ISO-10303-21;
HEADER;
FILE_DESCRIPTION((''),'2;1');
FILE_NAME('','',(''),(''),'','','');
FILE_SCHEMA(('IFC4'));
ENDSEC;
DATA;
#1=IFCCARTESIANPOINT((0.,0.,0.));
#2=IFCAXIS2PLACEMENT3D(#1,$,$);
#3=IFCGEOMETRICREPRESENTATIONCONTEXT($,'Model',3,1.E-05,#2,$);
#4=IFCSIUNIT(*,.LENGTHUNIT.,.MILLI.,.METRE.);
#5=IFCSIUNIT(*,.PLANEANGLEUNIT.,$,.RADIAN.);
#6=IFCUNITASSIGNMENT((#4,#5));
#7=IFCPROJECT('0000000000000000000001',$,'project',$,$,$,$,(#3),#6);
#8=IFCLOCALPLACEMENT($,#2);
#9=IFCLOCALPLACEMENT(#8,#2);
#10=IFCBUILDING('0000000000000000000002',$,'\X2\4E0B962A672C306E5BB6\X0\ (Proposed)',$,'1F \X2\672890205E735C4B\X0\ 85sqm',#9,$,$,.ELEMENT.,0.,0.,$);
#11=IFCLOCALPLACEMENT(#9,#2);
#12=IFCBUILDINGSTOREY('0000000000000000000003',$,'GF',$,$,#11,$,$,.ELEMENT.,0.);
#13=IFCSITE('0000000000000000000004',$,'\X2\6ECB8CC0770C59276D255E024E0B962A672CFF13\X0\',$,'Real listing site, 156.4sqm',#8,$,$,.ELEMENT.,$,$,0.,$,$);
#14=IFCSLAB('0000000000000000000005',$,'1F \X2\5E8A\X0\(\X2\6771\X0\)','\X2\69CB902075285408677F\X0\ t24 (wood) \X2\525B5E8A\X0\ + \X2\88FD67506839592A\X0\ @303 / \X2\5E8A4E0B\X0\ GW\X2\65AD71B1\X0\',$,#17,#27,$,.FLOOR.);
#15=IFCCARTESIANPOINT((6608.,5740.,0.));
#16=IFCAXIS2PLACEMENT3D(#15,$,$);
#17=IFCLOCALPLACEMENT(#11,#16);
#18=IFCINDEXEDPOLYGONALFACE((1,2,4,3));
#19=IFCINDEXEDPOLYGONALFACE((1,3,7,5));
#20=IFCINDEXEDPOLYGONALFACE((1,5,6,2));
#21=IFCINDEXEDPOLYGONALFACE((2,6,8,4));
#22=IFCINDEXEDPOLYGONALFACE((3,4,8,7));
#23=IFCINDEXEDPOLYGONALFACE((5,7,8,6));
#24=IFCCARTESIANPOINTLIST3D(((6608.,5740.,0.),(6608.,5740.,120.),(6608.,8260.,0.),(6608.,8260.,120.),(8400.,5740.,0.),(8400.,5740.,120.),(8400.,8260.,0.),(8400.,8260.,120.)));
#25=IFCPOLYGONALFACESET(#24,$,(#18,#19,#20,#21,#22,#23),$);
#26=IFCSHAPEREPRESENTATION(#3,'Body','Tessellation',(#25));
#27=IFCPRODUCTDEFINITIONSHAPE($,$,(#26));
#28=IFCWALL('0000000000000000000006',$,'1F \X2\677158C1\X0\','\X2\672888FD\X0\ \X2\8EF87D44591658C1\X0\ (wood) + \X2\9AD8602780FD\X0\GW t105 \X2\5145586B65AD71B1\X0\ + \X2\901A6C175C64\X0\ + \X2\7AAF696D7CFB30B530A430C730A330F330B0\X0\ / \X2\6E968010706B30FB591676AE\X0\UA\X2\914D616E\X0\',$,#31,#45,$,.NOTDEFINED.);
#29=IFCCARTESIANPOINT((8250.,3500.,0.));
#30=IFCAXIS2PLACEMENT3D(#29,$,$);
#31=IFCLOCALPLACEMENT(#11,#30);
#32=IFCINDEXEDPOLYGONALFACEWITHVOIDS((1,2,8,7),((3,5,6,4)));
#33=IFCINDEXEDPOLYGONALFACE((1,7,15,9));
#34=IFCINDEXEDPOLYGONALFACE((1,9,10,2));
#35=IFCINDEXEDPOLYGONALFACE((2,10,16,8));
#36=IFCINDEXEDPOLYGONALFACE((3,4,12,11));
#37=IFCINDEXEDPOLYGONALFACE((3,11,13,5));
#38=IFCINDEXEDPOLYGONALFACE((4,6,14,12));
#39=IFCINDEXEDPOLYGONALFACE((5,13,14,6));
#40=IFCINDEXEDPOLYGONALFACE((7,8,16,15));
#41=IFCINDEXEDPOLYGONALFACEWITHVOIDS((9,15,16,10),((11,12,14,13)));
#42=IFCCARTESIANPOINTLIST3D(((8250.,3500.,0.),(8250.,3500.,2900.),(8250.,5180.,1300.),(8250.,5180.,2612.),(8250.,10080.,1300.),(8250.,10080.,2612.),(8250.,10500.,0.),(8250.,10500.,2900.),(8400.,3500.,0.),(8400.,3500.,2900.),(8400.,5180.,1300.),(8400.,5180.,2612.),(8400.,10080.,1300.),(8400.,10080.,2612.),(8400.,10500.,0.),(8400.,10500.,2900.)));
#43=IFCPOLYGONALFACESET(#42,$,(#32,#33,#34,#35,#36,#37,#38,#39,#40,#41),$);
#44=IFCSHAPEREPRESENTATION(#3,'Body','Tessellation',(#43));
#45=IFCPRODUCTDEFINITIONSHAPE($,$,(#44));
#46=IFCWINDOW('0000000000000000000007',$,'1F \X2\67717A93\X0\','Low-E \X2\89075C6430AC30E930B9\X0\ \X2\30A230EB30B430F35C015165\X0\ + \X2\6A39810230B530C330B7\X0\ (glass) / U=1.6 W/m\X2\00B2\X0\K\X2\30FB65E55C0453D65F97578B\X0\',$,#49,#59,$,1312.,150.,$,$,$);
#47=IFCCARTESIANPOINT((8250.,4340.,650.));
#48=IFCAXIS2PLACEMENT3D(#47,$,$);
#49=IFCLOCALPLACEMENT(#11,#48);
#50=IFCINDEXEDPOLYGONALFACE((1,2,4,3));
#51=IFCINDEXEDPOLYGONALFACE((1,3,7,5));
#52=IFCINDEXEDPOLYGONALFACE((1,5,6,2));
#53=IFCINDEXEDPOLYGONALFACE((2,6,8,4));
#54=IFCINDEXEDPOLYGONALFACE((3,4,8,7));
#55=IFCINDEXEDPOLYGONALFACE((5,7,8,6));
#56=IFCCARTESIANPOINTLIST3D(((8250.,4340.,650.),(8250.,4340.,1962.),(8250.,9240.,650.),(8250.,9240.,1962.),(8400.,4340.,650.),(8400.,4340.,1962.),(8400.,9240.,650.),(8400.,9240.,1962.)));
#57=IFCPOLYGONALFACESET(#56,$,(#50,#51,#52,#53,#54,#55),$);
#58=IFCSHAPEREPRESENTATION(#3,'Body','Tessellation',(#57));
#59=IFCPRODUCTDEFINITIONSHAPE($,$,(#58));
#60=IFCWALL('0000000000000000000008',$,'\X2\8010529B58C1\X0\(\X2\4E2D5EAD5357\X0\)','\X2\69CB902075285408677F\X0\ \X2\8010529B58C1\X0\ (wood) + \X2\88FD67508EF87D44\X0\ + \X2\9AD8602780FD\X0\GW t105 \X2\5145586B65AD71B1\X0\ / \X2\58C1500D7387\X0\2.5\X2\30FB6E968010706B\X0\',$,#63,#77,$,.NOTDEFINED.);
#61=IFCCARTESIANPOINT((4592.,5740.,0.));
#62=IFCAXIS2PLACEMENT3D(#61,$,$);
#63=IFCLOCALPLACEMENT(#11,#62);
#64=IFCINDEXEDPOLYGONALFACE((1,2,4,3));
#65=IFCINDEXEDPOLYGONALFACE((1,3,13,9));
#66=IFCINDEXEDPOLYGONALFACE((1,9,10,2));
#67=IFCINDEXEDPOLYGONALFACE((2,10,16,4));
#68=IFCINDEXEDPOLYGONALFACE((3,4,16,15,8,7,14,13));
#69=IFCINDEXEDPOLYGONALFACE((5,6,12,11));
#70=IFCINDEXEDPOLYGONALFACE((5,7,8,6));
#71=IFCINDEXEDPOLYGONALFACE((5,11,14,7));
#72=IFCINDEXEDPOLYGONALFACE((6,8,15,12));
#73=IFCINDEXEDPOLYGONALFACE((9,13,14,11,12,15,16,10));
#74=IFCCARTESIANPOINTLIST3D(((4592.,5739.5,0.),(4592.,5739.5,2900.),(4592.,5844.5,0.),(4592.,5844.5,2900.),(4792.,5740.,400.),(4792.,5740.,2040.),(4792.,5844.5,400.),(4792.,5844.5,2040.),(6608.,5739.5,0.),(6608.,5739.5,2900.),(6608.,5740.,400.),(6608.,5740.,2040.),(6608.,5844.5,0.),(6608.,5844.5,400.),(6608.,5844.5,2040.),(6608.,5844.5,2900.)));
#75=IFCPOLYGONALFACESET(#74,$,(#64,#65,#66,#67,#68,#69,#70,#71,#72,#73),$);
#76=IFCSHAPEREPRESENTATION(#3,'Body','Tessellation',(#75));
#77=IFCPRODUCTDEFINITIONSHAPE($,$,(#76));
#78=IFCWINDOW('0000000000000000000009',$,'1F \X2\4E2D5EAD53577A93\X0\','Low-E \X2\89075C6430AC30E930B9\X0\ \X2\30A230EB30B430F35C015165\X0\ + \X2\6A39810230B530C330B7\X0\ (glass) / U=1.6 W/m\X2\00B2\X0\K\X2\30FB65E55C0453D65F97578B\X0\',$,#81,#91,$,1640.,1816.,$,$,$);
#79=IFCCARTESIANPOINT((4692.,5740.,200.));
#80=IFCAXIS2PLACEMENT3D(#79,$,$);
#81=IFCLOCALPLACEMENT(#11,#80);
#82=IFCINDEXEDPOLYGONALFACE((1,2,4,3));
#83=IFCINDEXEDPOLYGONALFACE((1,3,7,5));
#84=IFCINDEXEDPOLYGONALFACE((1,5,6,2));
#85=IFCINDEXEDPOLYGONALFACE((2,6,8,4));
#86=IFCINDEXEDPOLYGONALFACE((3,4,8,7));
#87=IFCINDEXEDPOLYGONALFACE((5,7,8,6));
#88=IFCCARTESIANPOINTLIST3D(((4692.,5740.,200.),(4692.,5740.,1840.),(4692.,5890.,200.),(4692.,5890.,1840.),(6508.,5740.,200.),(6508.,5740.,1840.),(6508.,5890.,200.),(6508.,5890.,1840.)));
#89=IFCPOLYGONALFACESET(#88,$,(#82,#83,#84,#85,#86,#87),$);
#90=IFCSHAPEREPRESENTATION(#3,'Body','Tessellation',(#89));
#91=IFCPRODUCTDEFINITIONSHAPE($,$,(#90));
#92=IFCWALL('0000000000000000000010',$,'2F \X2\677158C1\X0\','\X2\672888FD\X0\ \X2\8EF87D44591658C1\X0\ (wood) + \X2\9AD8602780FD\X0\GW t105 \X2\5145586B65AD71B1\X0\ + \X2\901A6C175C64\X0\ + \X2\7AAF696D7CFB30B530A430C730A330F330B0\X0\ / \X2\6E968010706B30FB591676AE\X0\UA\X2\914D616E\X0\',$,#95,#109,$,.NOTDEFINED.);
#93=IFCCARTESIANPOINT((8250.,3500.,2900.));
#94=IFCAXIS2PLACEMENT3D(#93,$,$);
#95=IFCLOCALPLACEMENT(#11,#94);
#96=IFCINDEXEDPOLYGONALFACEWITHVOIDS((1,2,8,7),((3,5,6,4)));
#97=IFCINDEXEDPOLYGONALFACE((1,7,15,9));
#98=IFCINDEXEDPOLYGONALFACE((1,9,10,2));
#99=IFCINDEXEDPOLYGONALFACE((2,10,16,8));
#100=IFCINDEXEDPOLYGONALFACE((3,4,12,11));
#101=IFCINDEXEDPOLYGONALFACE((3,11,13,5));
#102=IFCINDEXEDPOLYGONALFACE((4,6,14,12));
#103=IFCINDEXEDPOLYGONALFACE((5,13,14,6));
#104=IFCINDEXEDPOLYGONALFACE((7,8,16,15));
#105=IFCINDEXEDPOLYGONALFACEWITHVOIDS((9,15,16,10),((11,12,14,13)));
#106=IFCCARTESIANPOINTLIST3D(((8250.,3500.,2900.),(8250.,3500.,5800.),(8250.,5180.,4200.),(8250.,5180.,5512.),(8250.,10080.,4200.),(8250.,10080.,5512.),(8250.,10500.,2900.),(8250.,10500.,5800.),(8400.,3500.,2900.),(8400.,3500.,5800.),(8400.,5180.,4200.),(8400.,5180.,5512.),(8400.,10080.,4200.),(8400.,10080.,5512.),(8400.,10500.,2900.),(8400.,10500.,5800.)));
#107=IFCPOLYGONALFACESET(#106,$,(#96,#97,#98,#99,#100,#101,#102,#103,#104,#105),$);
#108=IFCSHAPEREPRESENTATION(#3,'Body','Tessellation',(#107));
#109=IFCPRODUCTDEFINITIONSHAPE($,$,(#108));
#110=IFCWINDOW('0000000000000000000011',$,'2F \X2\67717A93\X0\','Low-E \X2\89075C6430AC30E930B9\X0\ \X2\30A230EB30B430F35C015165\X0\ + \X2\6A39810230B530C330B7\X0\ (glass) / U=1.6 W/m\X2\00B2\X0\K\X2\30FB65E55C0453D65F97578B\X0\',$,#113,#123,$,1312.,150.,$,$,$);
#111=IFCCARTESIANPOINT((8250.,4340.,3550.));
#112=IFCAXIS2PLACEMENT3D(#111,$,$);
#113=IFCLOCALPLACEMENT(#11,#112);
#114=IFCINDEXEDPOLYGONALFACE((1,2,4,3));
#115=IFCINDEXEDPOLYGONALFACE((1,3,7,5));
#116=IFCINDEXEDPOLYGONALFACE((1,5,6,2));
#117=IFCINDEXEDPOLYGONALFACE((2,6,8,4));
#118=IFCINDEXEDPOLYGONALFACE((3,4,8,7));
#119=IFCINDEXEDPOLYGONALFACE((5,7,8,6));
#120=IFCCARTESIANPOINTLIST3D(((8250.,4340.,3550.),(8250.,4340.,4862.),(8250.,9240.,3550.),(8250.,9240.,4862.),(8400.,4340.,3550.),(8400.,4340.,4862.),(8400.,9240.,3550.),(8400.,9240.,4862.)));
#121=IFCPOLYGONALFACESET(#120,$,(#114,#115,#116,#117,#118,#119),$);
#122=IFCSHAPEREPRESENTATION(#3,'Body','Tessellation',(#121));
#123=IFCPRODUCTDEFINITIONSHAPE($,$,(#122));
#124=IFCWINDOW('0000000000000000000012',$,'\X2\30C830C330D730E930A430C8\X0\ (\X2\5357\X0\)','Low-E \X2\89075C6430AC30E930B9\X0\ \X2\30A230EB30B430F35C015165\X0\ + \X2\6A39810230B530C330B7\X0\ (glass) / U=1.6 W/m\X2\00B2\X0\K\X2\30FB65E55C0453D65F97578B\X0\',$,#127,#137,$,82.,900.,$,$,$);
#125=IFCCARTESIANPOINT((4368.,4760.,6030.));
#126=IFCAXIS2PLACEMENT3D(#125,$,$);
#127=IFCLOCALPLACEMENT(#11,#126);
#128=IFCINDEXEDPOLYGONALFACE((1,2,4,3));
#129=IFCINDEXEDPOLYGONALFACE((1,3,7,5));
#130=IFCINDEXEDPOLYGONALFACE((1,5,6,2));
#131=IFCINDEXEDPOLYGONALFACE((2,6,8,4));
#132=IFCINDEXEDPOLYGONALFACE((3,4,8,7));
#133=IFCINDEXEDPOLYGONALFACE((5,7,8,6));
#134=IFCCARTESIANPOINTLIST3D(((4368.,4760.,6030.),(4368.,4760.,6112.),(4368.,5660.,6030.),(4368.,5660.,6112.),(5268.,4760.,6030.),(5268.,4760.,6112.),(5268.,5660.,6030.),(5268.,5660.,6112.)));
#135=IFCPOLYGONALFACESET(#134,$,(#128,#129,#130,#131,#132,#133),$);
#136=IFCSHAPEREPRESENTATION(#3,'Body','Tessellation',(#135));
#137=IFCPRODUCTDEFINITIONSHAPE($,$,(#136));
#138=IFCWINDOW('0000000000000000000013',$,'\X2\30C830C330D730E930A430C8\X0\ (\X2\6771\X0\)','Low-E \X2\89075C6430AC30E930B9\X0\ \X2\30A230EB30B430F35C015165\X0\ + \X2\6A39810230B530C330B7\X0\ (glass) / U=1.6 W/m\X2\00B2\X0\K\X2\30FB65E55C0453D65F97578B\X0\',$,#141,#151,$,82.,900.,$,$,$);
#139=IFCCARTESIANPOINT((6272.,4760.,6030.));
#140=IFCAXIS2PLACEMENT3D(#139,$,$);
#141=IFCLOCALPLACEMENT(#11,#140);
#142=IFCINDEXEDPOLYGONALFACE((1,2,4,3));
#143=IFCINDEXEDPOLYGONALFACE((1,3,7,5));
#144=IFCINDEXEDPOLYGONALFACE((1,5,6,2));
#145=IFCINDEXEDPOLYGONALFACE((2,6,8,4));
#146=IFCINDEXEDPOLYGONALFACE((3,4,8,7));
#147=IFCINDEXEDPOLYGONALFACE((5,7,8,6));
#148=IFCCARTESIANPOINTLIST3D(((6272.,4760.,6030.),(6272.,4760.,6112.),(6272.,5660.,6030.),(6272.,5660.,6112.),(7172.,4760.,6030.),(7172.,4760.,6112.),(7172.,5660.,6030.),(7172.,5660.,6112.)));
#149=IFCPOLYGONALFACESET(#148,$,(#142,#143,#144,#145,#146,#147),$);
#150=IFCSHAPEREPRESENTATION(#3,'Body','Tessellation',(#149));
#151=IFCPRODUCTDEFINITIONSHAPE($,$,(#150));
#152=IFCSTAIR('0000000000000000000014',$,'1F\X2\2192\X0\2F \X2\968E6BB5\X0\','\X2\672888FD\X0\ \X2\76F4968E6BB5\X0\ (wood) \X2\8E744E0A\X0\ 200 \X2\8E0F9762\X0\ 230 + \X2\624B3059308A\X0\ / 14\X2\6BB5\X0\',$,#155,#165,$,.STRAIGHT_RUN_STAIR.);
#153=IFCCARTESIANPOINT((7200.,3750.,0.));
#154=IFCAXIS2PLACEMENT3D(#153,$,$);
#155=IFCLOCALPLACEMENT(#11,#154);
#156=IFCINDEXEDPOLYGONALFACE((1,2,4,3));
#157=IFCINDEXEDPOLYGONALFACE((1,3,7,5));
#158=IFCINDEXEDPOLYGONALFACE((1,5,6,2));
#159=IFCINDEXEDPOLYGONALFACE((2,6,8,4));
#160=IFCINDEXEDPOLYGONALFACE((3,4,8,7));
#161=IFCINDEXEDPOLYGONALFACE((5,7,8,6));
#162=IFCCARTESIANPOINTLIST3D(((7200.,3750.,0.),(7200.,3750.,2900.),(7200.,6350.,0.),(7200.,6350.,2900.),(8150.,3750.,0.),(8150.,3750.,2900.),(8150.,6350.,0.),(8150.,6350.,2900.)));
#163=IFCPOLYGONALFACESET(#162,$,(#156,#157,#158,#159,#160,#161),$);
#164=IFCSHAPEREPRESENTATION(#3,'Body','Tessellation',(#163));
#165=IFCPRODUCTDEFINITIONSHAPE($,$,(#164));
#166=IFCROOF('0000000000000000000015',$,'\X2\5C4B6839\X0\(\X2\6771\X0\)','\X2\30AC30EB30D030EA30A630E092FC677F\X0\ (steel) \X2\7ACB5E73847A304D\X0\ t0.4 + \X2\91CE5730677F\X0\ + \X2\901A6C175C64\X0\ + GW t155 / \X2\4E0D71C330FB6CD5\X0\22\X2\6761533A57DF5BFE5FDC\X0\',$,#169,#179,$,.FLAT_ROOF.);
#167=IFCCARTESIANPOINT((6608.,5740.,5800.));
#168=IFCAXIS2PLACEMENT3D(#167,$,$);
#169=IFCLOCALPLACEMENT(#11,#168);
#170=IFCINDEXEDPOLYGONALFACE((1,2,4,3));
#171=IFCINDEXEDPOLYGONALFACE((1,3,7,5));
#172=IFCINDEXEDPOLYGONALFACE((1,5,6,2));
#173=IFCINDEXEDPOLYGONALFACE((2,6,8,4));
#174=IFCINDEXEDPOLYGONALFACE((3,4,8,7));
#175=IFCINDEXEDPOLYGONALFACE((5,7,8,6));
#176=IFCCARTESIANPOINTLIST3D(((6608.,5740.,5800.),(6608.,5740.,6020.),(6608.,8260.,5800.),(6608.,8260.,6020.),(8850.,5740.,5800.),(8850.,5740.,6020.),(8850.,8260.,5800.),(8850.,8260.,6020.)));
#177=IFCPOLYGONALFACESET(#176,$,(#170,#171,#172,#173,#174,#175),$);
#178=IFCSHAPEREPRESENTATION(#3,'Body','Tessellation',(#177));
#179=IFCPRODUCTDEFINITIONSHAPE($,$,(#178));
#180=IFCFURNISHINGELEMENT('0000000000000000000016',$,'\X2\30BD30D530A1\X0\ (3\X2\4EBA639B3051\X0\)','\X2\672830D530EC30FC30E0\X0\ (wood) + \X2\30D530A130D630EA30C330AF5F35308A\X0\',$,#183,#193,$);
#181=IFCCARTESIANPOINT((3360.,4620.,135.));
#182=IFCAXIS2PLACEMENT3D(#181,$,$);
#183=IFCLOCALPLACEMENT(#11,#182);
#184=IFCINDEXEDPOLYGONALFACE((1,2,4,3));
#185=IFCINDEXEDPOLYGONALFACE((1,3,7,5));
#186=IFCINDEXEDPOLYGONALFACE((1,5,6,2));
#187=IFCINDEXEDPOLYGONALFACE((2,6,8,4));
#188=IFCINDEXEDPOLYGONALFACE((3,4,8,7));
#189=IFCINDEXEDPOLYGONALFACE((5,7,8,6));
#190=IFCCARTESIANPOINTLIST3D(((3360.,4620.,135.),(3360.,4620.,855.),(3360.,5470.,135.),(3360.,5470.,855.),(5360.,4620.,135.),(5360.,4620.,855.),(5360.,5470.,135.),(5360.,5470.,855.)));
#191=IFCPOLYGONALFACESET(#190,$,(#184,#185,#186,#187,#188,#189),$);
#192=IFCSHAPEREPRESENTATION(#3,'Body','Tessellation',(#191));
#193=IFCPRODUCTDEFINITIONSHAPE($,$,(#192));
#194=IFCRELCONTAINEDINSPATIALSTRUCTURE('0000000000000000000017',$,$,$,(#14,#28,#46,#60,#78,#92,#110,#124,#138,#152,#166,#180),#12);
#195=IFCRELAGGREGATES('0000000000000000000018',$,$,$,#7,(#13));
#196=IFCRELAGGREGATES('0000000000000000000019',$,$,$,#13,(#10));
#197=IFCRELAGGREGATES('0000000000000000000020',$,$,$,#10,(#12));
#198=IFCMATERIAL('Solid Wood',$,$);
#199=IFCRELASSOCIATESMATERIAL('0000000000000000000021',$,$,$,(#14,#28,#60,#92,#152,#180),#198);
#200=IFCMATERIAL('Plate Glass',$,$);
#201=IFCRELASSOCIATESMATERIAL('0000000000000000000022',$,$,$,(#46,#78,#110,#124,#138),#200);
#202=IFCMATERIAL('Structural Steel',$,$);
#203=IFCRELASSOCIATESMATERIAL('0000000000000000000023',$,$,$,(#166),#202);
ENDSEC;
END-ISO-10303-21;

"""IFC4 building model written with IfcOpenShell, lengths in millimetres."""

from ifc_helpers import new_model, si_unit, frame, frame_2d, origin, place, context, project, spatial, rectangle, extrude, material, element, fill, save


model = new_model("IFC4")

# Units and contexts
model_context = context("Model", 3, precision=1e-05, world=origin())
ifc_project = project(units=[si_unit("LENGTHUNIT", "METRE", prefix="MILLI"), si_unit("PLANEANGLEUNIT", "RADIAN")], contexts=[model_context])

# Site, building, storey
site_placement = place(None, origin())
site = spatial("IfcSite", under=ifc_project, at=site_placement, Name="滋賀県大津市下阪本３", ObjectType="Real listing site, 156.4sqm", CompositionType="ELEMENT", RefElevation=0.0)
building_placement = place(site_placement, origin())
building = spatial("IfcBuilding", under=site, at=building_placement, Name="下阪本の家 (Proposed)", ObjectType="1F 木造平屋 85sqm", CompositionType="ELEMENT", ElevationOfRefHeight=0.0, ElevationOfTerrain=0.0)
storey_placement = place(building_placement, origin())
storey = spatial("IfcBuildingStorey", under=building, at=storey_placement, Name="GF", CompositionType="ELEMENT", Elevation=0.0)

# Slab
ifc_material_1 = material(Name="Solid Wood")
slab_placement = place(storey_placement, frame((6608.0, 5740.0, 0.0)))
element("IfcSlab", 1, at=slab_placement, inside=storey, material=ifc_material_1, Name="1F 床(東)", Description="構造用合板 t24 (wood) 剛床 + 製材根太 @303 / 床下 GW断熱", PredefinedType="FLOOR", context=model_context, shape_type="SweptSolid", body=[
    extrude(rectangle(XDim=1792.0, YDim=2520.0, at=frame_2d((896.0, 1260.0))), frame((6608.0, 5740.0, 0.0)), (0.0, 0.0, 1.0), 120.0),
])

# Walls, openings, windows
wall_1_placement = place(storey_placement, frame((8250.0, 3500.0, 0.0)))
wall_1 = element("IfcWall", 2, at=wall_1_placement, inside=storey, material=ifc_material_1, Name="1F 東壁", Description="木製 軸組外壁 (wood) + 高性能GW t105 充填断熱 + 通気層 + 窯業系サイディング / 準耐火・外皮UA配慮", PredefinedType="NOTDEFINED", context=model_context, shape_type="SweptSolid", body=[
    extrude(rectangle(XDim=150.0, YDim=7000.0, at=frame_2d((75.0, 3500.0))), frame((8250.0, 3500.0, 0.0)), (0.0, 0.0, 1.0), 2900.0),
])
opening_1_placement = place(storey_placement, frame((8250.0, 4340.0, 650.0)))
opening_1 = element("IfcOpeningElement", 3, at=opening_1_placement, cuts=wall_1, PredefinedType="NOTDEFINED", context=model_context, shape_type="SweptSolid", body=[
    extrude(rectangle(XDim=150.0, YDim=4900.0, at=frame_2d((75.0, 2450.0))), frame((8250.0, 4340.0, 650.0)), (0.0, 0.0, 1.0), 1312.0),
])
ifc_material_2 = material(Name="Plate Glass")
window_1_placement = place(storey_placement, frame((8250.0, 4340.0, 650.0)))
window_1 = element("IfcWindow", 4, at=window_1_placement, inside=storey, material=ifc_material_2, Name="1F 東窓", Description="Low-E 複層ガラス アルゴン封入 + 樹脂サッシ (glass) / U=1.6 W/m²K・日射取得型", OverallHeight=1312.0, OverallWidth=150.0, context=model_context, shape_type="SweptSolid", body=[
    extrude(rectangle(XDim=150.0, YDim=4900.0, at=frame_2d((75.0, 2450.0))), frame((8250.0, 4340.0, 650.0)), (0.0, 0.0, 1.0), 1312.0),
])
fill(opening_1, window_1)
wall_2_placement = place(storey_placement, frame((4592.0, 5740.0, 0.0)))
wall_2 = element("IfcWall", 5, at=wall_2_placement, inside=storey, material=ifc_material_1, Name="耐力壁(中庭南)", Description="構造用合板 耐力壁 (wood) + 製材軸組 + 高性能GW t105 充填断熱 / 壁倍率2.5・準耐火", PredefinedType="NOTDEFINED", context=model_context, shape_type="SweptSolid", body=[
    extrude(rectangle(XDim=2016.0, YDim=105.0, at=frame_2d((1008.0, 52.0))), frame((4592.0, 5740.0, 0.0)), (0.0, 0.0, 1.0), 2900.0),
])
opening_2_placement = place(storey_placement, frame((4692.0, 5740.0, 200.0)))
opening_2 = element("IfcOpeningElement", 6, at=opening_2_placement, cuts=wall_2, PredefinedType="NOTDEFINED", context=model_context, shape_type="SweptSolid", body=[
    extrude(rectangle(XDim=1816.0, YDim=150.0, at=frame_2d((908.0, 75.0))), frame((4692.0, 5740.0, 200.0)), (0.0, 0.0, 1.0), 1640.0),
])
window_2_placement = place(storey_placement, frame((4692.0, 5740.0, 200.0)))
window_2 = element("IfcWindow", 7, at=window_2_placement, inside=storey, material=ifc_material_2, Name="1F 中庭南窓", Description="Low-E 複層ガラス アルゴン封入 + 樹脂サッシ (glass) / U=1.6 W/m²K・日射取得型", OverallHeight=1640.0, OverallWidth=1816.0, context=model_context, shape_type="SweptSolid", body=[
    extrude(rectangle(XDim=1816.0, YDim=150.0, at=frame_2d((908.0, 75.0))), frame((4692.0, 5740.0, 200.0)), (0.0, 0.0, 1.0), 1640.0),
])
fill(opening_2, window_2)

# Wall, opening, window
wall_3_placement = place(storey_placement, frame((8250.0, 3500.0, 2900.0)))
wall_3 = element("IfcWall", 8, at=wall_3_placement, inside=storey, material=ifc_material_1, Name="2F 東壁", Description="木製 軸組外壁 (wood) + 高性能GW t105 充填断熱 + 通気層 + 窯業系サイディング / 準耐火・外皮UA配慮", PredefinedType="NOTDEFINED", context=model_context, shape_type="SweptSolid", body=[
    extrude(rectangle(XDim=150.0, YDim=7000.0, at=frame_2d((75.0, 3500.0))), frame((8250.0, 3500.0, 2900.0)), (0.0, 0.0, 1.0), 2900.0),
])
opening_3_placement = place(storey_placement, frame((8250.0, 4340.0, 3550.0)))
opening_3 = element("IfcOpeningElement", 9, at=opening_3_placement, cuts=wall_3, PredefinedType="NOTDEFINED", context=model_context, shape_type="SweptSolid", body=[
    extrude(rectangle(XDim=150.0, YDim=4900.0, at=frame_2d((75.0, 2450.0))), frame((8250.0, 4340.0, 3550.0)), (0.0, 0.0, 1.0), 1312.0),
])
window_3_placement = place(storey_placement, frame((8250.0, 4340.0, 3550.0)))
window_3 = element("IfcWindow", 10, at=window_3_placement, inside=storey, material=ifc_material_2, Name="2F 東窓", Description="Low-E 複層ガラス アルゴン封入 + 樹脂サッシ (glass) / U=1.6 W/m²K・日射取得型", OverallHeight=1312.0, OverallWidth=150.0, context=model_context, shape_type="SweptSolid", body=[
    extrude(rectangle(XDim=150.0, YDim=4900.0, at=frame_2d((75.0, 2450.0))), frame((8250.0, 4340.0, 3550.0)), (0.0, 0.0, 1.0), 1312.0),
])
fill(opening_3, window_3)

# Windows
window_4_placement = place(storey_placement, frame((4368.0, 4760.0, 6030.0)))
element("IfcWindow", 11, at=window_4_placement, inside=storey, material=ifc_material_2, Name="トップライト (南)", Description="Low-E 複層ガラス アルゴン封入 + 樹脂サッシ (glass) / U=1.6 W/m²K・日射取得型", OverallHeight=82.0, OverallWidth=900.0, context=model_context, shape_type="SweptSolid", body=[
    extrude(rectangle(XDim=900.0, YDim=900.0, at=frame_2d((450.0, 450.0))), frame((4368.0, 4760.0, 6030.0)), (0.0, 0.0, 1.0), 82.0),
])
window_5_placement = place(storey_placement, frame((6272.0, 4760.0, 6030.0)))
element("IfcWindow", 12, at=window_5_placement, inside=storey, material=ifc_material_2, Name="トップライト (東)", Description="Low-E 複層ガラス アルゴン封入 + 樹脂サッシ (glass) / U=1.6 W/m²K・日射取得型", OverallHeight=82.0, OverallWidth=900.0, context=model_context, shape_type="SweptSolid", body=[
    extrude(rectangle(XDim=900.0, YDim=900.0, at=frame_2d((450.0, 450.0))), frame((6272.0, 4760.0, 6030.0)), (0.0, 0.0, 1.0), 82.0),
])

# Stair
stair_placement = place(storey_placement, frame((7200.0, 3750.0, 0.0)))
element("IfcStair", 13, at=stair_placement, inside=storey, material=ifc_material_1, Name="1F→2F 階段", Description="木製 直階段 (wood) 蹴上 200 踏面 230 + 手すり / 14段", PredefinedType="STRAIGHT_RUN_STAIR", context=model_context, shape_type="SweptSolid", body=[
    extrude(rectangle(XDim=950.0, YDim=2600.0, at=frame_2d((475.0, 1300.0))), frame((7200.0, 3750.0, 0.0)), (0.0, 0.0, 1.0), 2900.0),
])

# Roof
ifc_material_3 = material(Name="Structural Steel")
roof_placement = place(storey_placement, frame((6608.0, 5740.0, 5800.0)))
element("IfcRoof", 14, at=roof_placement, inside=storey, material=ifc_material_3, Name="屋根(東)", Description="ガルバリウム鋼板 (steel) 立平葺き t0.4 + 野地板 + 通気層 + GW t155 / 不燃・法22条区域対応", PredefinedType="FLAT_ROOF", context=model_context, shape_type="SweptSolid", body=[
    extrude(rectangle(XDim=2242.0, YDim=2520.0, at=frame_2d((1121.0, 1260.0))), frame((6608.0, 5740.0, 5800.0)), (0.0, 0.0, 1.0), 220.0),
])

# Furnishing element
furnishing_1_placement = place(storey_placement, frame((3360.0, 4620.0, 135.0)))
element("IfcFurnishingElement", 15, at=furnishing_1_placement, inside=storey, material=ifc_material_1, Name="ソファ (3人掛け)", Description="木フレーム (wood) + ファブリック張り", context=model_context, shape_type="SweptSolid", body=[
    extrude(rectangle(XDim=2000.0, YDim=850.0, at=frame_2d((1000.0, 425.0))), frame((3360.0, 4620.0, 135.0)), (0.0, 0.0, 1.0), 720.0),
])

save(model, "model.ifc")
